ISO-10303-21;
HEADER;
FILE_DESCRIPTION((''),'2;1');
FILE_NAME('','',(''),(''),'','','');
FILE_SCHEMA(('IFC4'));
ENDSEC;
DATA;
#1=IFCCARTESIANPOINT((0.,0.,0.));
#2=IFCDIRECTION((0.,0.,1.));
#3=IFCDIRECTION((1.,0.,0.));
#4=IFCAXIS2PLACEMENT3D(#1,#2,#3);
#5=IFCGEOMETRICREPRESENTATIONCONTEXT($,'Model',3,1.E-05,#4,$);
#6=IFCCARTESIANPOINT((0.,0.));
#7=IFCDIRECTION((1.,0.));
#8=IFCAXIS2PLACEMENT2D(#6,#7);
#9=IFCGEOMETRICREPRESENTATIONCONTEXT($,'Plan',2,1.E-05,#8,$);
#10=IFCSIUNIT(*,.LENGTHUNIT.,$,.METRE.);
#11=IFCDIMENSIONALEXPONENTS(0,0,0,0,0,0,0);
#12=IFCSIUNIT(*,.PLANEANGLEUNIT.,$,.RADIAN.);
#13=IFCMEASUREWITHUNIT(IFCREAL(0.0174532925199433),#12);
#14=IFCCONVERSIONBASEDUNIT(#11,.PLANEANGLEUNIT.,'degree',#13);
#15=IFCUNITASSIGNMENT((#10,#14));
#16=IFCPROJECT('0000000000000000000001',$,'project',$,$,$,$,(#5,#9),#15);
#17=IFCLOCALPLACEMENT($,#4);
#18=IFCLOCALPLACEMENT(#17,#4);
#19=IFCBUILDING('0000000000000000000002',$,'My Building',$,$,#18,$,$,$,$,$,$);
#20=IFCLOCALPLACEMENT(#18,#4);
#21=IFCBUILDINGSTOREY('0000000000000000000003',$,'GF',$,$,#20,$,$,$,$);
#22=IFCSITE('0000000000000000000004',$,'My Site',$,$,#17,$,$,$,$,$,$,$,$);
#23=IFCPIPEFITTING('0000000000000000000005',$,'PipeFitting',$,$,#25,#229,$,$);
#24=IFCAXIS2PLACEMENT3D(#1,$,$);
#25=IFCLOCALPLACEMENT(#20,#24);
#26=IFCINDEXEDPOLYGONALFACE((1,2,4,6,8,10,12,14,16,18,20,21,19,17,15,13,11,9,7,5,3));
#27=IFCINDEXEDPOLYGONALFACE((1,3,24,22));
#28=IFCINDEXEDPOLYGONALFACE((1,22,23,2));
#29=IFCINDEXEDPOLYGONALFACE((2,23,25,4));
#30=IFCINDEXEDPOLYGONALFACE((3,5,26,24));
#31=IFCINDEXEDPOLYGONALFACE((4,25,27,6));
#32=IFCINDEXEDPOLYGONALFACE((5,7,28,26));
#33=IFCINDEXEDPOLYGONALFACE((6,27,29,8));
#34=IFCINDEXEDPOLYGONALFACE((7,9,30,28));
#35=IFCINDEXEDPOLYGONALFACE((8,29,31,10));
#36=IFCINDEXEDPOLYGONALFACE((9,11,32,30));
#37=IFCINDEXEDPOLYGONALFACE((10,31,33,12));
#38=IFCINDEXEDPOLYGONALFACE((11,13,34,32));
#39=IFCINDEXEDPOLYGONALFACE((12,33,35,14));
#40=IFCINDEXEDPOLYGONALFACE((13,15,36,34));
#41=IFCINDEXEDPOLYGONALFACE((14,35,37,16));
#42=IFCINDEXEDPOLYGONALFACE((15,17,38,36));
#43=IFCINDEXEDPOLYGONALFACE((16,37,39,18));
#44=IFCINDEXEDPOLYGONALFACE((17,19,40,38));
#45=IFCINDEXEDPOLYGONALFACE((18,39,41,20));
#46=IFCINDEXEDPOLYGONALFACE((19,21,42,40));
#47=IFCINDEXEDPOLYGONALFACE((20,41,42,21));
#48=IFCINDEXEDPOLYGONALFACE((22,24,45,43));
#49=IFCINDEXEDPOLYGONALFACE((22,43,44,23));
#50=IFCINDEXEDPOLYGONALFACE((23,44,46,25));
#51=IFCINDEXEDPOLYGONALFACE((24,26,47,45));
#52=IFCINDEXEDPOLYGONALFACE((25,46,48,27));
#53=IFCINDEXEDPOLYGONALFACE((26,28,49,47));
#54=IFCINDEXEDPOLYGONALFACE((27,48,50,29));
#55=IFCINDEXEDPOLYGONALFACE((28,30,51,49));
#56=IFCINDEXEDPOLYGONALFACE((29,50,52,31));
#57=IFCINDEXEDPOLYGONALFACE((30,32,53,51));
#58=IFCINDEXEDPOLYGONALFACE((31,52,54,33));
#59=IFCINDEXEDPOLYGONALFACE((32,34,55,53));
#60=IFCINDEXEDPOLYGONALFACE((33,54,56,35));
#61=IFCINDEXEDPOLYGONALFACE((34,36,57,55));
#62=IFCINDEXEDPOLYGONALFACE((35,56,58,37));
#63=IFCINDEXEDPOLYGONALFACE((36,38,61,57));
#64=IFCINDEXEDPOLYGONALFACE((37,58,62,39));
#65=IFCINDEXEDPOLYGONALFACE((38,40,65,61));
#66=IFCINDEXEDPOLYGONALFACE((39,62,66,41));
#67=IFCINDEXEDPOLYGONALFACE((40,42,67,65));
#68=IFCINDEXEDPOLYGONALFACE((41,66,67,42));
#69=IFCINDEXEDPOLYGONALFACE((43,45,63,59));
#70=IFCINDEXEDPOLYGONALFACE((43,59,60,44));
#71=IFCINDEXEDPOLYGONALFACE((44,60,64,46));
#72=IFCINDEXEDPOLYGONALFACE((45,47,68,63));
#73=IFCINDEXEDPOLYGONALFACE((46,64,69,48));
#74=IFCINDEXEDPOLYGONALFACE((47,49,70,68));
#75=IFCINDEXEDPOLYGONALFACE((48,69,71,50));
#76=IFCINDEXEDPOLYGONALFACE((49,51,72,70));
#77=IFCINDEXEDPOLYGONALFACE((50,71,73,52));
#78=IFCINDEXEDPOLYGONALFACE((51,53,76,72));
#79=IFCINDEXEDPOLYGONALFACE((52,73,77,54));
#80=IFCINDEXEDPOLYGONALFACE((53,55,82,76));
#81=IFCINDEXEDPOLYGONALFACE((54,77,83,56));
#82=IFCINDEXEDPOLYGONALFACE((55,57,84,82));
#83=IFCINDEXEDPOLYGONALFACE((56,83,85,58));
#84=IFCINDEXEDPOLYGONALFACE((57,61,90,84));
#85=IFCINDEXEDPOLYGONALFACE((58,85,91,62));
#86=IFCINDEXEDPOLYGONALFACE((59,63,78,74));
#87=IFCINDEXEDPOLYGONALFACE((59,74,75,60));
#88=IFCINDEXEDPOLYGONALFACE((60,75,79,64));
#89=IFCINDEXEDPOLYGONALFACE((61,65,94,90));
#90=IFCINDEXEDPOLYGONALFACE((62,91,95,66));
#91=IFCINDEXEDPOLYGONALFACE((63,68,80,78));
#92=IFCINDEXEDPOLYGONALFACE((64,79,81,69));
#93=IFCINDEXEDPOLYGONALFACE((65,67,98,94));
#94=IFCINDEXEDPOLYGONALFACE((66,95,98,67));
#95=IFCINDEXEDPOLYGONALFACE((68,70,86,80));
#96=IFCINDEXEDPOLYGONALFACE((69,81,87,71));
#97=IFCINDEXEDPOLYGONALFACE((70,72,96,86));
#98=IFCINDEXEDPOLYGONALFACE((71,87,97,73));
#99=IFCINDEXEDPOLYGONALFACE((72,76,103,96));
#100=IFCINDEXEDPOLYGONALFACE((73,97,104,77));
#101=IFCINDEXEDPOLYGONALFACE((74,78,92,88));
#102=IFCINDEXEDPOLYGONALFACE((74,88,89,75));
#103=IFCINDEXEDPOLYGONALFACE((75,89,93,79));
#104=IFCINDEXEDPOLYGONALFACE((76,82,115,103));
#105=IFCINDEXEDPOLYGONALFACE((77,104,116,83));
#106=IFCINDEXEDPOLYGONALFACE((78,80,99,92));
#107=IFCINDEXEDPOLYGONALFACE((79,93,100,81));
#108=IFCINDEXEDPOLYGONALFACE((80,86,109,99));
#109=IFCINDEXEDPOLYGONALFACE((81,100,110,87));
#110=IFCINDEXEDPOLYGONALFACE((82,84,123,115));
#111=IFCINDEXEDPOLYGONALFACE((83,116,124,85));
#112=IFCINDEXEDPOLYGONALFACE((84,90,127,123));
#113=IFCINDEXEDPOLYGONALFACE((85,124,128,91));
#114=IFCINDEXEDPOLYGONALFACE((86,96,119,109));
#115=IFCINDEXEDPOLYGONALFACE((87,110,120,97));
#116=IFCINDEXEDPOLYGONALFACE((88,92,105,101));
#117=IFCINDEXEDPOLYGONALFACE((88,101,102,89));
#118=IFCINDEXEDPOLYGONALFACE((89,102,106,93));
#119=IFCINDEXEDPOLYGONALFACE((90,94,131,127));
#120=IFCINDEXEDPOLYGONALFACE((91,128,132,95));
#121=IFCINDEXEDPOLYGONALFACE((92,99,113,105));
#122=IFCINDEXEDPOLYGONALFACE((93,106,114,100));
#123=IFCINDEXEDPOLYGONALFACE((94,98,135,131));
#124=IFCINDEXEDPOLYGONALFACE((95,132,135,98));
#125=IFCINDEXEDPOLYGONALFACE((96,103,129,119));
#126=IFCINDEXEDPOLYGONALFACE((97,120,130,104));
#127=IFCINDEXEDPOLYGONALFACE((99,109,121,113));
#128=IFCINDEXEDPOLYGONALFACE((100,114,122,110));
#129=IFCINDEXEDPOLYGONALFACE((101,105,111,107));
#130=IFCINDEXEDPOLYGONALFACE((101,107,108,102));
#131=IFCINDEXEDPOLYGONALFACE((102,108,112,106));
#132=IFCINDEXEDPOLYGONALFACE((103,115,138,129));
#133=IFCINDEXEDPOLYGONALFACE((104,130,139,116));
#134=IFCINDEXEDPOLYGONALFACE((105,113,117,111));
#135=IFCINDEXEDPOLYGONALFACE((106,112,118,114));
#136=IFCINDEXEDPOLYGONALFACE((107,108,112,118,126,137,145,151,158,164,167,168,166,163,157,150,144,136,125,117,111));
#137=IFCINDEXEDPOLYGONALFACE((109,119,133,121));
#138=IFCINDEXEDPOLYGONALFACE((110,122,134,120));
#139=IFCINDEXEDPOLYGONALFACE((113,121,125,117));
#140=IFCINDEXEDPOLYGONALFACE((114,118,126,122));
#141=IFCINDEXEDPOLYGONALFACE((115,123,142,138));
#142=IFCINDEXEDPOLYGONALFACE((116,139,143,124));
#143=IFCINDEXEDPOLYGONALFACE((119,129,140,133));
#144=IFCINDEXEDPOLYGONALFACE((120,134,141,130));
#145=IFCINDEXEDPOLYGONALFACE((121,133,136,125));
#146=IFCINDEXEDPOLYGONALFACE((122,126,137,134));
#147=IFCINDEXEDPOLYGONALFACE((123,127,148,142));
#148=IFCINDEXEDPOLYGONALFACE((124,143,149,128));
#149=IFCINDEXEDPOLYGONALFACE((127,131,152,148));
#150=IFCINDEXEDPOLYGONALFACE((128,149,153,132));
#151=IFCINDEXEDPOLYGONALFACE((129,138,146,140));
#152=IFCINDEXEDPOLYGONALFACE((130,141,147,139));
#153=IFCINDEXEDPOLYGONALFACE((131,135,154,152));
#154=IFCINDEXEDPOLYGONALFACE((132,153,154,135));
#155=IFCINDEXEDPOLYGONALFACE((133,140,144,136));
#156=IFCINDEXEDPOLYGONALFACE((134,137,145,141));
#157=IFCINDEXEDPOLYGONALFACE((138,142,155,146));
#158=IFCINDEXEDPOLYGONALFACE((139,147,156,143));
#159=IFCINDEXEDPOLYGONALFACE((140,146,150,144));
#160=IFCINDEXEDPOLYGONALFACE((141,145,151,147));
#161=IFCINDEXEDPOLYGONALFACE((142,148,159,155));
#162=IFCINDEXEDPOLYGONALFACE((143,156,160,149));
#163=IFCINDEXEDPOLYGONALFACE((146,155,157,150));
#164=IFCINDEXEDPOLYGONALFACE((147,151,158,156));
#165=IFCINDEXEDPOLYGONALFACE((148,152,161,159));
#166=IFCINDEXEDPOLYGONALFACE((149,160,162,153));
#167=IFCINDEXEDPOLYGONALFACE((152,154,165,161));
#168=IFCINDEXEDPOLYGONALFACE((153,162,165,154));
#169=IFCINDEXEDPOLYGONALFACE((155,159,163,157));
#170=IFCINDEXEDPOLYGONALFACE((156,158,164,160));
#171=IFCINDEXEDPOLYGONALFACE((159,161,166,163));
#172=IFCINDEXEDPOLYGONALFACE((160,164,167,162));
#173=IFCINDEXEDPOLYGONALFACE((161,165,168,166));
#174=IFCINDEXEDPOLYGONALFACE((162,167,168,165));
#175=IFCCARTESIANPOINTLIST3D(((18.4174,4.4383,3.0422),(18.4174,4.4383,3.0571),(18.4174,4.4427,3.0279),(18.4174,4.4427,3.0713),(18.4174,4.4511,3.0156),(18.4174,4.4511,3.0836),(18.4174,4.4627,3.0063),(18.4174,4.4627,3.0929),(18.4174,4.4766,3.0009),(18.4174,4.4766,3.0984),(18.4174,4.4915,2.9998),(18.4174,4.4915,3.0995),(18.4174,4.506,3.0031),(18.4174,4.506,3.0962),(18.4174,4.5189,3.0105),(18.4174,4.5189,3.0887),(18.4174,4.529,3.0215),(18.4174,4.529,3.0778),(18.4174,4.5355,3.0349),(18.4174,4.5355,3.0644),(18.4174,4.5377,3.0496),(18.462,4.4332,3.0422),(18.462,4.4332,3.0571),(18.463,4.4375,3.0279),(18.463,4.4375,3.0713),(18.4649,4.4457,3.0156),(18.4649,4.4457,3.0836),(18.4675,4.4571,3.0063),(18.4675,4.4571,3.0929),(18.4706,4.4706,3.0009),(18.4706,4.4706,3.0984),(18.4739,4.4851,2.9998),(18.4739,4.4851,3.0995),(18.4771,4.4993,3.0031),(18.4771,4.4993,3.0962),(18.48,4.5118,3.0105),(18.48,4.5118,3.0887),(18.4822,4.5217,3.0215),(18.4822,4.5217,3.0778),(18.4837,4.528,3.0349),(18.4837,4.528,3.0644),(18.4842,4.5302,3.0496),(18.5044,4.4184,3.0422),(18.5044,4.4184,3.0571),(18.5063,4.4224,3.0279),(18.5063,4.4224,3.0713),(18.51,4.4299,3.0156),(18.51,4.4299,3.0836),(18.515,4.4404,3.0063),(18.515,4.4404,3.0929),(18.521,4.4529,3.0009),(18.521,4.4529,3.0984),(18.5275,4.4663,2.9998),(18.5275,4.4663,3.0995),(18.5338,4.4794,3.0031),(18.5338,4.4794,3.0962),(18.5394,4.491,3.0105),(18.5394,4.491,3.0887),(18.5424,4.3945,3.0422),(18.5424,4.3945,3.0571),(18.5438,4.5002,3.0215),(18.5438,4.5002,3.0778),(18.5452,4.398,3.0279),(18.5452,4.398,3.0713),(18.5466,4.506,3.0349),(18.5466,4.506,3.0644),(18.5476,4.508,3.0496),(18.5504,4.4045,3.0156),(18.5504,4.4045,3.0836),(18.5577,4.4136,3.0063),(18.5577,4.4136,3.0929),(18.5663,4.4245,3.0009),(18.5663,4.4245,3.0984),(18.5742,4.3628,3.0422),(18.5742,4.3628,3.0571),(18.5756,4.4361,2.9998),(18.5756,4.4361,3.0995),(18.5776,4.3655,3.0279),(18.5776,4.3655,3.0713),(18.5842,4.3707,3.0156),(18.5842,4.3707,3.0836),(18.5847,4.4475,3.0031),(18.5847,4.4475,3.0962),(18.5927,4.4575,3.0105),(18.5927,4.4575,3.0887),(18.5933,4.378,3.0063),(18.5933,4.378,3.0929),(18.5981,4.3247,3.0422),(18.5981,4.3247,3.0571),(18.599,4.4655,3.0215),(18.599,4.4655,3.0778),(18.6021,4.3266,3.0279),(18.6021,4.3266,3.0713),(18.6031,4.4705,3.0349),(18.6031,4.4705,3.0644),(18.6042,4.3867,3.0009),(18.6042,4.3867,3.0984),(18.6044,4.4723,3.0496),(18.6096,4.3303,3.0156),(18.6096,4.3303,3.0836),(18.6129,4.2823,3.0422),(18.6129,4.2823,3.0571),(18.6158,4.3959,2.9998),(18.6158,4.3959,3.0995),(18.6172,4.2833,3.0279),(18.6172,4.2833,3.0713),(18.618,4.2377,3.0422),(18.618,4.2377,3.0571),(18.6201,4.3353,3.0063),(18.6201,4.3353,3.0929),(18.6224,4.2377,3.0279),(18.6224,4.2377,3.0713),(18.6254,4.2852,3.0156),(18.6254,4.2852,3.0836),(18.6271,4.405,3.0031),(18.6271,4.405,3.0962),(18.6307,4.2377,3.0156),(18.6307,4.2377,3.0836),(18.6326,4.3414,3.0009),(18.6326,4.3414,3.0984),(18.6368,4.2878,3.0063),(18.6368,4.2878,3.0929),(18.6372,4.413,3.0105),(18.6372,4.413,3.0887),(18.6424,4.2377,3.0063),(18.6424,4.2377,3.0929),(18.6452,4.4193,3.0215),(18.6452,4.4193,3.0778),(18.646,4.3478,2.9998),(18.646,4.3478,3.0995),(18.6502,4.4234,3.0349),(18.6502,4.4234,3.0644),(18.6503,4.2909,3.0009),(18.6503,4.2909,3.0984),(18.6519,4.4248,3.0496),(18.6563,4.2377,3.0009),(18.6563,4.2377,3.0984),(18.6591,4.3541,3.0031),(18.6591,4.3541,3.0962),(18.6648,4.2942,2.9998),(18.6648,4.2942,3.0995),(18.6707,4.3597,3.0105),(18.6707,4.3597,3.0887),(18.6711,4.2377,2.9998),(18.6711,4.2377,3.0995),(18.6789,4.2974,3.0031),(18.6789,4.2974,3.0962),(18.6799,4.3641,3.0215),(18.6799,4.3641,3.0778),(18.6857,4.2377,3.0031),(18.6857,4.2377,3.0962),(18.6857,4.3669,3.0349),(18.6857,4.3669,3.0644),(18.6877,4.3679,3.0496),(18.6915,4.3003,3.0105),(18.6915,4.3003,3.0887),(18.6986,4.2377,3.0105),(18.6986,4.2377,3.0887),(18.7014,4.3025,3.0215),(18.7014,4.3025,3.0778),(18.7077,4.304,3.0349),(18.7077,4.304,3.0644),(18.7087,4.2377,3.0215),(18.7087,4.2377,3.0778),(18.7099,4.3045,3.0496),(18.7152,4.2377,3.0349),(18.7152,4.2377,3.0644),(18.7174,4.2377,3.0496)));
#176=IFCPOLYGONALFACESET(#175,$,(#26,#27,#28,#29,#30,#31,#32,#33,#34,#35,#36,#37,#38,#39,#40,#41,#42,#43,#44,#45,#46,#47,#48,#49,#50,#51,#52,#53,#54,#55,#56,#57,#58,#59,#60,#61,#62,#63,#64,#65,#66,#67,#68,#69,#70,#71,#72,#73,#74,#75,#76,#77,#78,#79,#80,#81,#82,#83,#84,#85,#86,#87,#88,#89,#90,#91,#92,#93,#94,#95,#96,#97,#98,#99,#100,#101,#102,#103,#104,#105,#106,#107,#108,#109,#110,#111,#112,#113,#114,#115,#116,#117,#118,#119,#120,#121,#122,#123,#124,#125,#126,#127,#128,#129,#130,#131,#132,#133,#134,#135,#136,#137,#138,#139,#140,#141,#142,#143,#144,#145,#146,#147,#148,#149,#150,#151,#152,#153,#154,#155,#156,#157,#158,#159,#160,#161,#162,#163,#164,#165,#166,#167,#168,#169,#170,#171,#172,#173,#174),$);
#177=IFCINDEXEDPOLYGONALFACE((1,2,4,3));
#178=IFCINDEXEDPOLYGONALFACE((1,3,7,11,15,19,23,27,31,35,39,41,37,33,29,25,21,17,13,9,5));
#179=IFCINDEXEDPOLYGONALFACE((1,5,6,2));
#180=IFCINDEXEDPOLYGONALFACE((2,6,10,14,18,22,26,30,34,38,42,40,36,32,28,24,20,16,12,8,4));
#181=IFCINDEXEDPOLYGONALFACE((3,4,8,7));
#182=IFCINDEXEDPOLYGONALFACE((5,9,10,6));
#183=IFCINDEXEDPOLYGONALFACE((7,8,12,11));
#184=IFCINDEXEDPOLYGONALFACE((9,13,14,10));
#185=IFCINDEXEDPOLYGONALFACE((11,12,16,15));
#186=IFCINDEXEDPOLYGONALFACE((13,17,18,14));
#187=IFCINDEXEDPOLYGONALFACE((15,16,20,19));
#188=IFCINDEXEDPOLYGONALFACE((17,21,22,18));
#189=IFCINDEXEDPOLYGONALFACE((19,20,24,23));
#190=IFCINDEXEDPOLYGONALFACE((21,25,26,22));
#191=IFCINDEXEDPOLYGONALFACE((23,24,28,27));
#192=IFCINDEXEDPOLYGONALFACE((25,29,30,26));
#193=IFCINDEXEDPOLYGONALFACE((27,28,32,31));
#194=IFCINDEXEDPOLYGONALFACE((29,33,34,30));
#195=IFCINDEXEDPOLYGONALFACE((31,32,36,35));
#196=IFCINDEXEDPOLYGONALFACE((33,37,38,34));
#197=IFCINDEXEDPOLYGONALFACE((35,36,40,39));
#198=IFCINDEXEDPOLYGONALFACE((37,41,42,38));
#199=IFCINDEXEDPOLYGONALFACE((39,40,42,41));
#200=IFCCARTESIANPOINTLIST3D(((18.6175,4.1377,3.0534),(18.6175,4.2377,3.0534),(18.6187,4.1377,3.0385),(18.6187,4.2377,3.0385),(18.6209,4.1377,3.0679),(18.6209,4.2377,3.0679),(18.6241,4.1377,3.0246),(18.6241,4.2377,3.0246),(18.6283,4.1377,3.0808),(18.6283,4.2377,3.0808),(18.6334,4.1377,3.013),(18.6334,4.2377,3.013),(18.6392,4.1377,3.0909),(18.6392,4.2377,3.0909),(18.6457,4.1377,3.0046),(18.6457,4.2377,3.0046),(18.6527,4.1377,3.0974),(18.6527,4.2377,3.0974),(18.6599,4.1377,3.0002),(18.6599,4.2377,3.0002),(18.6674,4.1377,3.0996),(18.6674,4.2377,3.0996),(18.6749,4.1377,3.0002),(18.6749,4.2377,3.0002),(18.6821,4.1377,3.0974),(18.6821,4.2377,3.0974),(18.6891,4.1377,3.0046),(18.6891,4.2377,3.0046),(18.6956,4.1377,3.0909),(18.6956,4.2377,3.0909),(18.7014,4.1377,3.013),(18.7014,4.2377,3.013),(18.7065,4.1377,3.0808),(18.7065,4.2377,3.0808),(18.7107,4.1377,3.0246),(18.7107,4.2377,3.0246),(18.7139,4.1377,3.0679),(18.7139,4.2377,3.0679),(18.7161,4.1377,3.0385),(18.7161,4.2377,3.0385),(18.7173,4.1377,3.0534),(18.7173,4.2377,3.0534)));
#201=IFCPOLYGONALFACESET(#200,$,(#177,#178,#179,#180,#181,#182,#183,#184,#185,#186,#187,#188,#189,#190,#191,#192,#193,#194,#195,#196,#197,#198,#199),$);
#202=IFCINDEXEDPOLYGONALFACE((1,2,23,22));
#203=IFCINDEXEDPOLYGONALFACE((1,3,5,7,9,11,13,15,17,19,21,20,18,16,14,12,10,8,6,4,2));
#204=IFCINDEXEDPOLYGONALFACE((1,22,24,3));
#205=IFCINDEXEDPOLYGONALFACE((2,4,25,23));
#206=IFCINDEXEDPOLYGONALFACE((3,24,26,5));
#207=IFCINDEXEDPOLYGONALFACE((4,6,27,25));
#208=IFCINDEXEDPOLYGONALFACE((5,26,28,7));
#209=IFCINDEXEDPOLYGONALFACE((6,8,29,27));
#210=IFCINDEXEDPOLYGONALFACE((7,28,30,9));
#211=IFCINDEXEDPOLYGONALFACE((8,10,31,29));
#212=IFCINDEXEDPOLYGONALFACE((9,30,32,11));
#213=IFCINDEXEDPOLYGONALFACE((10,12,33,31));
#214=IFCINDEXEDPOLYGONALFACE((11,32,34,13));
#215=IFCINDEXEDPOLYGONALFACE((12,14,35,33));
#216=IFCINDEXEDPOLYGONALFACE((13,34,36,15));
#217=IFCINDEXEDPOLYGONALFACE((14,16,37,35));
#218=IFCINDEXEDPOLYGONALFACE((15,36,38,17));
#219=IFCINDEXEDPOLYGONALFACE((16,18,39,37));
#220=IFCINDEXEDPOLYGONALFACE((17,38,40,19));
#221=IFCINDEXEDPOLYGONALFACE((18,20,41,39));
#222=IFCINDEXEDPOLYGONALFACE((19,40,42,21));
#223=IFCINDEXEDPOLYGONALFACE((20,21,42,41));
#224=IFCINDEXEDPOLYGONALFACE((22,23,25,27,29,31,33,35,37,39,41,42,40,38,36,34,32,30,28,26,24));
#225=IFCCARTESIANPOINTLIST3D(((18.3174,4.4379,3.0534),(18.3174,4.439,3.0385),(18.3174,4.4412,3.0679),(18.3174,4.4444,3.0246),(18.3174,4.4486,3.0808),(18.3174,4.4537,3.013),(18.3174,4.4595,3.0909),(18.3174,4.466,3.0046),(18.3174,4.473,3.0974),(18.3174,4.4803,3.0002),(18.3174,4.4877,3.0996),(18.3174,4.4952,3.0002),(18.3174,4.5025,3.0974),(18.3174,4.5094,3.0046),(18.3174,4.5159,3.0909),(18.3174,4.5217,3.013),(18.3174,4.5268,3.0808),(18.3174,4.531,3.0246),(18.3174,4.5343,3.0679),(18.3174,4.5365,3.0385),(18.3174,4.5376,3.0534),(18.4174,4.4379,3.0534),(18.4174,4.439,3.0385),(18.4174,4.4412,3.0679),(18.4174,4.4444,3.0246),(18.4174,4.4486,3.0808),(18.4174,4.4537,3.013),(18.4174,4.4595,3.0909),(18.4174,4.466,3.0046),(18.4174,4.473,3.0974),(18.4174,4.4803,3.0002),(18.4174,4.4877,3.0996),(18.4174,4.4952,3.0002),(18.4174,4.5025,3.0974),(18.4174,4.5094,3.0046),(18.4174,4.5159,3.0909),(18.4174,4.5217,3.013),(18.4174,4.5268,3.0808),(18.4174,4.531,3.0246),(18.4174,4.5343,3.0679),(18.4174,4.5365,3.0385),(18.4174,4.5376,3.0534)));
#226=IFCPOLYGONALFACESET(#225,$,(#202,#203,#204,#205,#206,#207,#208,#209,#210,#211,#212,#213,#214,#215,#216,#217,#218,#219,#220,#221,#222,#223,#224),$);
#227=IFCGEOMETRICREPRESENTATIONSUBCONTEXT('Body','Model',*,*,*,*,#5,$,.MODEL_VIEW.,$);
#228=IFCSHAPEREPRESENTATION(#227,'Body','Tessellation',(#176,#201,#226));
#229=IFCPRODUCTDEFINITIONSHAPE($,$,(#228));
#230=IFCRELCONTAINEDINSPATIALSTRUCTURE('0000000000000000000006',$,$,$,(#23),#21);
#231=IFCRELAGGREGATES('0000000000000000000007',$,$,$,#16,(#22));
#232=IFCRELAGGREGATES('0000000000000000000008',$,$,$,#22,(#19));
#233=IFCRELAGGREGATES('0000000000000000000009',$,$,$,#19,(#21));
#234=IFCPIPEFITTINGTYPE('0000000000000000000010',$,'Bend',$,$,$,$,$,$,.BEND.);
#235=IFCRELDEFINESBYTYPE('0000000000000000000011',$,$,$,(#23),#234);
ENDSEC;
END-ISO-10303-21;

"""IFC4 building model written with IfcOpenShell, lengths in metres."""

from ifc_helpers import new_model, entity, si_unit, converted_unit, frame, origin_with_axes, origin_2d_with_axis, place, context, subcontext, project, spatial, line, indexed_curve, circle, outline, extrude, source, transform, mapped, type_object, type_shapes, element, save


model = new_model("IFC4")

# Units and contexts
model_context = context("Model", 3, precision=1e-05, world=origin_with_axes())
plan_context = context("Plan", 2, precision=1e-05, world=origin_2d_with_axis())
body_context_1 = subcontext(model_context, "Body", "Model", "MODEL_VIEW")
ifc_project = project(units=[si_unit("LENGTHUNIT", "METRE"), converted_unit("PLANEANGLEUNIT", "degree", entity("IfcReal", 0.0174532925199433), si_unit("PLANEANGLEUNIT", "RADIAN"), dimensions=[0, 0, 0, 0, 0, 0, 0])], contexts=[model_context, plan_context])

# Site, building, storey
site_placement = place(None, origin_with_axes())
site = spatial("IfcSite", under=ifc_project, at=site_placement, Name="My Site")
building_placement = place(site_placement, origin_with_axes())
building = spatial("IfcBuilding", under=site, at=building_placement, Name="My Building")
storey_placement = place(building_placement, origin_with_axes())
storey = spatial("IfcBuildingStorey", under=building, at=storey_placement, Name="GF")

# Pipe fitting, opening
pipe_fitting_type = type_object("IfcPipeFittingType", Name="Bend", PredefinedType="BEND")
shared_shape_1 = source(origin_with_axes(), body_context_1, "Body", "SolidModel", [
    entity("IfcSweptDiskSolid", entity("IfcIndexedPolyCurve", entity("IfcCartesianPointList3D", [[0.0, 0.0, 0.1], [0.0, -0.0732, 0.2768], [0.0, -0.25, 0.35]]), [entity("IfcArcIndex", [1, 2, 3])]), 0.05),
    extrude(circle(Radius=0.05), origin_with_axes(), (0.0, 0.0, 1.0), 0.1),
    extrude(circle(Radius=0.05), frame((0.0, -0.25, 0.35), z_axis=(0.0, -1.0, 0.0), x_axis=(1.0, 0.0, 0.0)), (0.0, 0.0, 1.0), 0.1),
])
type_shapes(pipe_fitting_type, [shared_shape_1])
pipe_fitting_1_placement = place(storey_placement, frame((18.6674, 4.1377, 3.0496), z_axis=(0.0, 1.0, 0.0), x_axis=(0.0, 0.0, 1.0)))
pipe_fitting_1 = element("IfcPipeFitting", 1, at=pipe_fitting_1_placement, inside=storey, type_object=pipe_fitting_type, Name="PipeFitting", context=body_context_1, shape_type="MappedRepresentation", body=[
    mapped(shared_shape_1, transform((0.0, 0.0, 0.0), x_axis=(1.0, 0.0, 0.0), y_axis=(0.0, 1.0, 0.0), z_axis=(0.0, 0.0, 1.0), scale=1.0)),
])
opening_1_placement = place(pipe_fitting_1_placement, frame((-3.0496, -18.6674, -4.1377), z_axis=(1.0, 0.0, 0.0), x_axis=(0.0, 1.0, 0.0)))
element("IfcOpeningElement", 2, at=opening_1_placement, cuts=pipe_fitting_1, PredefinedType="OPENING", context=body_context_1, shape_type="SweptSolid", body=[
    extrude(outline(indexed_curve([(0.0, 0.0), (0.5, 0.0), (0.5, 0.5), (0.0, 0.5)], segments=[line(1, 2, 3, 4, 1)])), origin_with_axes(), (0.0, 0.0, 1.0), 0.5),
])

save(model, "model.ifc")
